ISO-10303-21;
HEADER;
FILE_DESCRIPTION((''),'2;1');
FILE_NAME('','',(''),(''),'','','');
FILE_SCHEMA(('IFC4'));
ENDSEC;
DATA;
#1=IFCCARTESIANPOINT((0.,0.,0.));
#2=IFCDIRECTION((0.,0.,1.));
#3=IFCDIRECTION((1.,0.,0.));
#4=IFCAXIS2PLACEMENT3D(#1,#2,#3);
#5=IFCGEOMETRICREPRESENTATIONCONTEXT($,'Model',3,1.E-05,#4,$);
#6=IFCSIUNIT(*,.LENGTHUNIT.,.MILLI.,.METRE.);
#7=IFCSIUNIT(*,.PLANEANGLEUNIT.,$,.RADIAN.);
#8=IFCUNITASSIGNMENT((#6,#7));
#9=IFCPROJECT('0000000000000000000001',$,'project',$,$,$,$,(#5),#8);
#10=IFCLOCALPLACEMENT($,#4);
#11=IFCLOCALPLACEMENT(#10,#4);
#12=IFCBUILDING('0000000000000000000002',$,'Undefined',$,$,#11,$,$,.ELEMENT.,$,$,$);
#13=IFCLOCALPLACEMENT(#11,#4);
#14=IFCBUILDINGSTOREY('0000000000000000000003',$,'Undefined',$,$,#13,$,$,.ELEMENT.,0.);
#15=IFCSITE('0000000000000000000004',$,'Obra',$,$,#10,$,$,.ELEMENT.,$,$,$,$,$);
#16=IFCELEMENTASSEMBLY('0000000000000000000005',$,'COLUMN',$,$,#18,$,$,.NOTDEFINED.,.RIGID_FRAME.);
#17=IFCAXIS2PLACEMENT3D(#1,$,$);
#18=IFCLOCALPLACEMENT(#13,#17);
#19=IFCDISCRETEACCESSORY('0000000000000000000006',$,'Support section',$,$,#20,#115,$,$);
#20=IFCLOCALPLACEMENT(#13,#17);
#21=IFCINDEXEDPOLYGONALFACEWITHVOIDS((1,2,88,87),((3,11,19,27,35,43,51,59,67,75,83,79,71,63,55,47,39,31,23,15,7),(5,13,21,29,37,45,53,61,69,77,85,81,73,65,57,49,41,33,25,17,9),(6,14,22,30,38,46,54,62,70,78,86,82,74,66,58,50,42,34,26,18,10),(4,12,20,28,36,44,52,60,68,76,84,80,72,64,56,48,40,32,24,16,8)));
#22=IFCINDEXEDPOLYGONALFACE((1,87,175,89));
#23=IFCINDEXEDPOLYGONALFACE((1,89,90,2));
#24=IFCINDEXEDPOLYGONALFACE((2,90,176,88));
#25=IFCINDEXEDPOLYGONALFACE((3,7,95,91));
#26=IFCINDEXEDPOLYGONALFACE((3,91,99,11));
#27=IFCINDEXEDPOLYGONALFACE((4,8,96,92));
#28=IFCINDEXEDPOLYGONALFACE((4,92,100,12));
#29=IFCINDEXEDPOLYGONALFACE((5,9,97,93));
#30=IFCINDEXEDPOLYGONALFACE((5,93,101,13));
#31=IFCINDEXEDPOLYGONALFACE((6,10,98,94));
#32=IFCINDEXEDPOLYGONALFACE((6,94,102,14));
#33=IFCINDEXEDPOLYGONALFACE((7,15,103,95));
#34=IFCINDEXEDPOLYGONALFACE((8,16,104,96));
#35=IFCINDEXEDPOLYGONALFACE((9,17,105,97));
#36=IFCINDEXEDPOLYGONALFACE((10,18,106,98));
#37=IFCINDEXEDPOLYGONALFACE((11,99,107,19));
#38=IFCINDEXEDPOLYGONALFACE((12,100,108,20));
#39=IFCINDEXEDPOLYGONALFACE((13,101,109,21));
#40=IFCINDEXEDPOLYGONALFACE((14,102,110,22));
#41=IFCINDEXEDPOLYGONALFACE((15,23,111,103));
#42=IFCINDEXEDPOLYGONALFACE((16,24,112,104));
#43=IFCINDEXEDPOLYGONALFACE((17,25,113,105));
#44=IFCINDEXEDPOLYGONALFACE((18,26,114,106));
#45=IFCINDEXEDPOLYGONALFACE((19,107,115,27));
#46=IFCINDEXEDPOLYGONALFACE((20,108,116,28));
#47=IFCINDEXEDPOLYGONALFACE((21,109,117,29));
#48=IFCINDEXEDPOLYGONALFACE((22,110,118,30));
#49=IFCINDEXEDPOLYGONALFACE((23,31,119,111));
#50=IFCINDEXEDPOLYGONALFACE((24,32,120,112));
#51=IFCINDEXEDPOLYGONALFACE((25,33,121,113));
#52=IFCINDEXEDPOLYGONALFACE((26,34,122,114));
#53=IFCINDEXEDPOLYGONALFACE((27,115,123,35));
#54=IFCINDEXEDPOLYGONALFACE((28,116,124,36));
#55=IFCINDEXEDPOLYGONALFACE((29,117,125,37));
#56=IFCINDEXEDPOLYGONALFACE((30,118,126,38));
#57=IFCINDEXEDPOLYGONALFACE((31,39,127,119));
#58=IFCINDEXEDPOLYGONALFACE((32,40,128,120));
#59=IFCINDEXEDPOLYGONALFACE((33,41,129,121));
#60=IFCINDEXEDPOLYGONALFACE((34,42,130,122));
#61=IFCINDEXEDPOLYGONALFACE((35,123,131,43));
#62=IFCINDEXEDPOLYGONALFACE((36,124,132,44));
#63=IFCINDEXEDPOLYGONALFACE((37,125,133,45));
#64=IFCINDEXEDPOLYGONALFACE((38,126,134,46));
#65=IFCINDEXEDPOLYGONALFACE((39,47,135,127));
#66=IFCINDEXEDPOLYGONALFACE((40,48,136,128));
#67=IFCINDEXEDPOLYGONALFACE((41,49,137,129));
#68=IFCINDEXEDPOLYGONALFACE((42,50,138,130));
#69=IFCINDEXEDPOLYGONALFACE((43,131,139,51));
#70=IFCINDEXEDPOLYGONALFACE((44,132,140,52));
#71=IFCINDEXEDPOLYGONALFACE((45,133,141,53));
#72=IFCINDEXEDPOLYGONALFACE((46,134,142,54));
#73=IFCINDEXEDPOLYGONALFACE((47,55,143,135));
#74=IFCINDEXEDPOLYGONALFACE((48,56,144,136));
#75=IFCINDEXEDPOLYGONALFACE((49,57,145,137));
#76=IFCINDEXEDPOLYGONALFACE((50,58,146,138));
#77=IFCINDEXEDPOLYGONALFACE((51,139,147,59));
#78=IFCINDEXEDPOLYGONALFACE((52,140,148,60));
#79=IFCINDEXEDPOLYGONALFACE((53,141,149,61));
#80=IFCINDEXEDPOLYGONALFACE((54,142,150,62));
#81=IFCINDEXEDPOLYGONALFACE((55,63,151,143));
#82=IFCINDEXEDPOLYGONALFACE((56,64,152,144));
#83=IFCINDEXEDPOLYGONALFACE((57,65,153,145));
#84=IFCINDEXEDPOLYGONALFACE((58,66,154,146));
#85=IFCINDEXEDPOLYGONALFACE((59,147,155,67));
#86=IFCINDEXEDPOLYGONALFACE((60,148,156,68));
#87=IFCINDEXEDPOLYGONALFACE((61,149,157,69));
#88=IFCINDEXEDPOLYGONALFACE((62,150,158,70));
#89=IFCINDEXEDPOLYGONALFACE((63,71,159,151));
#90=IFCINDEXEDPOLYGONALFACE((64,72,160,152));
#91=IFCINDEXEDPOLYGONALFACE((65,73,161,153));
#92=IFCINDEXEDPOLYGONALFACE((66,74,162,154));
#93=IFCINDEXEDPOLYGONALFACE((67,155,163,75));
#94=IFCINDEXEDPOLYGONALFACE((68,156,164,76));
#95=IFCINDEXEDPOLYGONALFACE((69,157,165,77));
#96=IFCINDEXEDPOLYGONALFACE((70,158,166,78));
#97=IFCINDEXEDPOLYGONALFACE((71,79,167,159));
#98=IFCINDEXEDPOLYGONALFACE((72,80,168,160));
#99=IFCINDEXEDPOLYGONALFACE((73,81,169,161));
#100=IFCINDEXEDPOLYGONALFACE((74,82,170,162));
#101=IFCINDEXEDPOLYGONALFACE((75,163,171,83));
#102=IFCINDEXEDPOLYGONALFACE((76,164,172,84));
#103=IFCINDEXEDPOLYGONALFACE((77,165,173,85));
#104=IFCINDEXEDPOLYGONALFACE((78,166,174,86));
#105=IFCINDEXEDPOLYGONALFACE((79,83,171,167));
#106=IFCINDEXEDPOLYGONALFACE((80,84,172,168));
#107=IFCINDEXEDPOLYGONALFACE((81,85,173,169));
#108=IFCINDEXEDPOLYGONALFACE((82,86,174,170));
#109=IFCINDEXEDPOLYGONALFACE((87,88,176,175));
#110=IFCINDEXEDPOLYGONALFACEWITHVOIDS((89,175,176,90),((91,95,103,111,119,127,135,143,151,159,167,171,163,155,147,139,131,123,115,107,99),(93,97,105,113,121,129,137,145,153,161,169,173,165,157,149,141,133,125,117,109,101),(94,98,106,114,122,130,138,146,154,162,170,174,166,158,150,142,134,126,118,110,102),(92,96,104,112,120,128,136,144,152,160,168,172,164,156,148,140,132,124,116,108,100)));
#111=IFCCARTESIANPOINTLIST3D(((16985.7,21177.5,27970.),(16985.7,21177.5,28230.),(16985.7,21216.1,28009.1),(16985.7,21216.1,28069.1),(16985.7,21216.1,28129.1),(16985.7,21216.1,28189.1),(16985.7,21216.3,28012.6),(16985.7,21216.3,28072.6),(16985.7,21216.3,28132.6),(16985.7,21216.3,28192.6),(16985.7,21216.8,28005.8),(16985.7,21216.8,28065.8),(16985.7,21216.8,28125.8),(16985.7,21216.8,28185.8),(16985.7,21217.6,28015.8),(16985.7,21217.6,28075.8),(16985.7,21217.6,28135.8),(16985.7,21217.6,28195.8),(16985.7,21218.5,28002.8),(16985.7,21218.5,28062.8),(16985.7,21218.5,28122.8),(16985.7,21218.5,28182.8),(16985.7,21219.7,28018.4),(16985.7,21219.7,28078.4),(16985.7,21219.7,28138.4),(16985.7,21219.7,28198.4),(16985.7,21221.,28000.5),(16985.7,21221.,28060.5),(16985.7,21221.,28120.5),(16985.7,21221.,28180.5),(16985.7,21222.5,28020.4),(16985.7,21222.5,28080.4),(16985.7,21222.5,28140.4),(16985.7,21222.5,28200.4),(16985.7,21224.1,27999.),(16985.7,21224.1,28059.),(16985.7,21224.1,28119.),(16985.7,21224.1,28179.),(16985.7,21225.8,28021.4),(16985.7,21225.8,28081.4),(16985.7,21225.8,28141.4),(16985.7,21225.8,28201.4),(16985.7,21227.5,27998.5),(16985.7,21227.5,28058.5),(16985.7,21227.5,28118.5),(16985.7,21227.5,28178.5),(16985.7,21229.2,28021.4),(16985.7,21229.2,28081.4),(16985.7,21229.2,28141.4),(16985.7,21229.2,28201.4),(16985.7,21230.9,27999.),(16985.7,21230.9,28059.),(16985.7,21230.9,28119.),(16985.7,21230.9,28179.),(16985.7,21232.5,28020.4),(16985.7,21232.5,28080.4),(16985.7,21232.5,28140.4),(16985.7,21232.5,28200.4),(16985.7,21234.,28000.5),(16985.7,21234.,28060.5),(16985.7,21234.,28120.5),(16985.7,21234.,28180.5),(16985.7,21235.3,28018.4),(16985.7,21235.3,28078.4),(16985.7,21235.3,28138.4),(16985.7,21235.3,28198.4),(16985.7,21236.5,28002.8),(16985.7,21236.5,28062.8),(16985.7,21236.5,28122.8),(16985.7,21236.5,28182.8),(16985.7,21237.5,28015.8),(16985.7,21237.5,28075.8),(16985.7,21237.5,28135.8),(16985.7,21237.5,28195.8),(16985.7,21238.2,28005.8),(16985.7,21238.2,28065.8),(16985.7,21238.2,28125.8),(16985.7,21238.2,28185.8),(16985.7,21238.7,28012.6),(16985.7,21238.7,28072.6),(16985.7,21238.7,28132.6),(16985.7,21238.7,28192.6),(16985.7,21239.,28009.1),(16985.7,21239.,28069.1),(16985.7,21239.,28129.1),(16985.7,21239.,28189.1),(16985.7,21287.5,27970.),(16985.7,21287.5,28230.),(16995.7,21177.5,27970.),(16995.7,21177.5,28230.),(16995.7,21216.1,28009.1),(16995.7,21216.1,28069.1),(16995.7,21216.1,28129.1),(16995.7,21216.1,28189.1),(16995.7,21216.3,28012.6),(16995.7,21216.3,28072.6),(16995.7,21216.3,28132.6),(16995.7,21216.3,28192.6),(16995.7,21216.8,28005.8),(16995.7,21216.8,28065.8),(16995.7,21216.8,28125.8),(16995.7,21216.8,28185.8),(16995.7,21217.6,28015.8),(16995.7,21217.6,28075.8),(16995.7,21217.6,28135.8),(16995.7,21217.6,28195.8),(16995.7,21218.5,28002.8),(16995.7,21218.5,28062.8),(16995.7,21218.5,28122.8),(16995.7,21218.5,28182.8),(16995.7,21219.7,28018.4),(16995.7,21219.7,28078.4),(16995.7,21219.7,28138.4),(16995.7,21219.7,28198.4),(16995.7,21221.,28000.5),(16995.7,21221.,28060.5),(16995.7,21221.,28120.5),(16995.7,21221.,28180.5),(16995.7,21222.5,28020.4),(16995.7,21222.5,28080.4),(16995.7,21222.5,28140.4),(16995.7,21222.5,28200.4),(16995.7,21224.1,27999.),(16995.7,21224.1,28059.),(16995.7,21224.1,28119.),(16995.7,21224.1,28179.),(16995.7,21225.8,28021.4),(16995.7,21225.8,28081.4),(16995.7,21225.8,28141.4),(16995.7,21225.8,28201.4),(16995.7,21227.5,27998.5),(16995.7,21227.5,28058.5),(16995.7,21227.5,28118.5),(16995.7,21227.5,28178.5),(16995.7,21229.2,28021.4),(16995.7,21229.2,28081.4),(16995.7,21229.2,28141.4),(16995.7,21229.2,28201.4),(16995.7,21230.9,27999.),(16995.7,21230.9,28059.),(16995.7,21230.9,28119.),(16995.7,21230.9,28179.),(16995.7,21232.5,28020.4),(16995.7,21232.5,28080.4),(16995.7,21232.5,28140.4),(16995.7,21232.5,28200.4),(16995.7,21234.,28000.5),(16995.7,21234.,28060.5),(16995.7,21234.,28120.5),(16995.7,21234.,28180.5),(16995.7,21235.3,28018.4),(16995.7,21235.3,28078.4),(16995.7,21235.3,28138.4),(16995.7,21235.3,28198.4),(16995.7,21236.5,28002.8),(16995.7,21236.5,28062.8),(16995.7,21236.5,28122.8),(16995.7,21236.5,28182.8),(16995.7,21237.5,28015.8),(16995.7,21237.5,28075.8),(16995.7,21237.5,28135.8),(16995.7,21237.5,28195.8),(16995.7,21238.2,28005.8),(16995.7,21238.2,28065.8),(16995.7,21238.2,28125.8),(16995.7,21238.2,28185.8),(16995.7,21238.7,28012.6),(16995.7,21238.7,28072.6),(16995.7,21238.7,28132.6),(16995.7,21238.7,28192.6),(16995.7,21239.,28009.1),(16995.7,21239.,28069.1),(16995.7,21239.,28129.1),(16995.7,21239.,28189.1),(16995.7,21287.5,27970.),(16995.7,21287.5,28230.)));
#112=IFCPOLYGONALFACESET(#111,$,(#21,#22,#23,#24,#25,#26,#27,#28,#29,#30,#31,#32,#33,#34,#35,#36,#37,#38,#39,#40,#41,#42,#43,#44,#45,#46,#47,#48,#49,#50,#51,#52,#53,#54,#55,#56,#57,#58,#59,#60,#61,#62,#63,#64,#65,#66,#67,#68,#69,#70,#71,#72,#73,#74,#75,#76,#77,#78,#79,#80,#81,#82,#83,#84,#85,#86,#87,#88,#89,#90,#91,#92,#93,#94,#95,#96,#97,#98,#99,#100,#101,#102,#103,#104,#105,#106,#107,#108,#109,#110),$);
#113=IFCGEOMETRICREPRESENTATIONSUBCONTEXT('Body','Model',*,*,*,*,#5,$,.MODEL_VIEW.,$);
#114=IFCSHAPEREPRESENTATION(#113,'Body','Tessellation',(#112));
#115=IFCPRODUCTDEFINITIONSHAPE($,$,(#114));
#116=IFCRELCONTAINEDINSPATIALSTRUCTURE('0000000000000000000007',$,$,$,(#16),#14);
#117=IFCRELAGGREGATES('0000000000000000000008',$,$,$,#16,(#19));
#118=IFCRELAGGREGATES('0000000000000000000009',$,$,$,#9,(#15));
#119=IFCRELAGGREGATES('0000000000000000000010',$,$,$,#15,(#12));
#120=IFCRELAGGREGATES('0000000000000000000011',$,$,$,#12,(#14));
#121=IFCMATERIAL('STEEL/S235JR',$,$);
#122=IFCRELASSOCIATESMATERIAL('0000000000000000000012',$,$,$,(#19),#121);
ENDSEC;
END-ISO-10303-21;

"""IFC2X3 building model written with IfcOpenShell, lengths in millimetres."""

from ifc_helpers import new_model, si_unit, frame, origin_with_axes, origin_2d_with_axis, place, context, subcontext, project, spatial, rectangle, circle, extrude, source, transform, mapped, material, element, aggregate, save


model = new_model("IFC2X3")

# Units and contexts
model_context = context("Model", 3, precision=1e-05, world=origin_with_axes())
body_context = subcontext(model_context, "Body", "Model", "MODEL_VIEW")
ifc_project = project(units=[si_unit("LENGTHUNIT", "METRE", prefix="MILLI"), si_unit("PLANEANGLEUNIT", "RADIAN")], contexts=[model_context])

# Site, building, storey
site_placement = place(None, origin_with_axes())
site = spatial("IfcSite", under=ifc_project, at=site_placement, Name="Obra", CompositionType="ELEMENT")
building_placement = place(site_placement, origin_with_axes())
building = spatial("IfcBuilding", under=site, at=building_placement, Name="Undefined", CompositionType="ELEMENT")
storey_placement = place(building_placement, origin_with_axes())
storey = spatial("IfcBuildingStorey", under=building, at=storey_placement, Name="Undefined", CompositionType="ELEMENT", Elevation=0.0)

# Element assembly
assembly_1_placement = place(storey_placement, origin_with_axes())
assembly_1 = element("IfcElementAssembly", 1, at=assembly_1_placement, inside=storey, Name="COLUMN", AssemblyPlace="NOTDEFINED", PredefinedType="RIGID_FRAME")
ifc_material_1 = material(Name="STEEL/S235JR")

# Shared definitions
shared_shape_1 = source(origin_with_axes(), body_context, "Body", "SweptSolid", [
    extrude(circle(Radius=11.5, at=origin_2d_with_axis()), frame((0.0, -14.4, 0.0), z_axis=(0.0, 1.0, 0.0), x_axis=(1.0, 0.0, 0.0)), (0.0, 0.0, 1.0), 10.2),
])

# Discrete accessory, opening
discrete_accessory_1_placement = place(assembly_1_placement, frame((16990.7, 21232.5, 27970.0), z_axis=(0.0, 0.0, 1.0), x_axis=(0.0, 1.0, 0.0)))
discrete_accessory_1 = element("IfcDiscreteAccessory", 2, at=discrete_accessory_1_placement, material=ifc_material_1, Name="Support section", context=body_context, shape_type="SweptSolid", body=[
    extrude(rectangle(XDim=10.0, YDim=110.0, at=origin_2d_with_axis()), frame((0.0, 0.0, 260.0), z_axis=(0.0, 0.0, -1.0), x_axis=(0.0, 1.0, 0.0)), (0.0, 0.0, 1.0), 260.0),
])
opening_1_placement = place(assembly_1_placement, frame((17000.0, 21277.5, 28300.0), z_axis=(0.0, -1.0, 0.0), x_axis=(0.0, 0.0, -1.0)))
element("IfcOpeningElement", 3, at=opening_1_placement, cuts=discrete_accessory_1, ObjectType="Opening", context=body_context, shape_type="MappedRepresentation", body=[
    mapped(shared_shape_1, transform((110.0, 0.0, 50.0))),
    mapped(shared_shape_1, transform((170.0, 0.0, 50.0))),
    mapped(shared_shape_1, transform((230.0, 0.0, 50.0))),
    mapped(shared_shape_1, transform((290.0, 0.0, 50.0))),
])
aggregate(assembly_1, [discrete_accessory_1])

save(model, "model.ifc")
